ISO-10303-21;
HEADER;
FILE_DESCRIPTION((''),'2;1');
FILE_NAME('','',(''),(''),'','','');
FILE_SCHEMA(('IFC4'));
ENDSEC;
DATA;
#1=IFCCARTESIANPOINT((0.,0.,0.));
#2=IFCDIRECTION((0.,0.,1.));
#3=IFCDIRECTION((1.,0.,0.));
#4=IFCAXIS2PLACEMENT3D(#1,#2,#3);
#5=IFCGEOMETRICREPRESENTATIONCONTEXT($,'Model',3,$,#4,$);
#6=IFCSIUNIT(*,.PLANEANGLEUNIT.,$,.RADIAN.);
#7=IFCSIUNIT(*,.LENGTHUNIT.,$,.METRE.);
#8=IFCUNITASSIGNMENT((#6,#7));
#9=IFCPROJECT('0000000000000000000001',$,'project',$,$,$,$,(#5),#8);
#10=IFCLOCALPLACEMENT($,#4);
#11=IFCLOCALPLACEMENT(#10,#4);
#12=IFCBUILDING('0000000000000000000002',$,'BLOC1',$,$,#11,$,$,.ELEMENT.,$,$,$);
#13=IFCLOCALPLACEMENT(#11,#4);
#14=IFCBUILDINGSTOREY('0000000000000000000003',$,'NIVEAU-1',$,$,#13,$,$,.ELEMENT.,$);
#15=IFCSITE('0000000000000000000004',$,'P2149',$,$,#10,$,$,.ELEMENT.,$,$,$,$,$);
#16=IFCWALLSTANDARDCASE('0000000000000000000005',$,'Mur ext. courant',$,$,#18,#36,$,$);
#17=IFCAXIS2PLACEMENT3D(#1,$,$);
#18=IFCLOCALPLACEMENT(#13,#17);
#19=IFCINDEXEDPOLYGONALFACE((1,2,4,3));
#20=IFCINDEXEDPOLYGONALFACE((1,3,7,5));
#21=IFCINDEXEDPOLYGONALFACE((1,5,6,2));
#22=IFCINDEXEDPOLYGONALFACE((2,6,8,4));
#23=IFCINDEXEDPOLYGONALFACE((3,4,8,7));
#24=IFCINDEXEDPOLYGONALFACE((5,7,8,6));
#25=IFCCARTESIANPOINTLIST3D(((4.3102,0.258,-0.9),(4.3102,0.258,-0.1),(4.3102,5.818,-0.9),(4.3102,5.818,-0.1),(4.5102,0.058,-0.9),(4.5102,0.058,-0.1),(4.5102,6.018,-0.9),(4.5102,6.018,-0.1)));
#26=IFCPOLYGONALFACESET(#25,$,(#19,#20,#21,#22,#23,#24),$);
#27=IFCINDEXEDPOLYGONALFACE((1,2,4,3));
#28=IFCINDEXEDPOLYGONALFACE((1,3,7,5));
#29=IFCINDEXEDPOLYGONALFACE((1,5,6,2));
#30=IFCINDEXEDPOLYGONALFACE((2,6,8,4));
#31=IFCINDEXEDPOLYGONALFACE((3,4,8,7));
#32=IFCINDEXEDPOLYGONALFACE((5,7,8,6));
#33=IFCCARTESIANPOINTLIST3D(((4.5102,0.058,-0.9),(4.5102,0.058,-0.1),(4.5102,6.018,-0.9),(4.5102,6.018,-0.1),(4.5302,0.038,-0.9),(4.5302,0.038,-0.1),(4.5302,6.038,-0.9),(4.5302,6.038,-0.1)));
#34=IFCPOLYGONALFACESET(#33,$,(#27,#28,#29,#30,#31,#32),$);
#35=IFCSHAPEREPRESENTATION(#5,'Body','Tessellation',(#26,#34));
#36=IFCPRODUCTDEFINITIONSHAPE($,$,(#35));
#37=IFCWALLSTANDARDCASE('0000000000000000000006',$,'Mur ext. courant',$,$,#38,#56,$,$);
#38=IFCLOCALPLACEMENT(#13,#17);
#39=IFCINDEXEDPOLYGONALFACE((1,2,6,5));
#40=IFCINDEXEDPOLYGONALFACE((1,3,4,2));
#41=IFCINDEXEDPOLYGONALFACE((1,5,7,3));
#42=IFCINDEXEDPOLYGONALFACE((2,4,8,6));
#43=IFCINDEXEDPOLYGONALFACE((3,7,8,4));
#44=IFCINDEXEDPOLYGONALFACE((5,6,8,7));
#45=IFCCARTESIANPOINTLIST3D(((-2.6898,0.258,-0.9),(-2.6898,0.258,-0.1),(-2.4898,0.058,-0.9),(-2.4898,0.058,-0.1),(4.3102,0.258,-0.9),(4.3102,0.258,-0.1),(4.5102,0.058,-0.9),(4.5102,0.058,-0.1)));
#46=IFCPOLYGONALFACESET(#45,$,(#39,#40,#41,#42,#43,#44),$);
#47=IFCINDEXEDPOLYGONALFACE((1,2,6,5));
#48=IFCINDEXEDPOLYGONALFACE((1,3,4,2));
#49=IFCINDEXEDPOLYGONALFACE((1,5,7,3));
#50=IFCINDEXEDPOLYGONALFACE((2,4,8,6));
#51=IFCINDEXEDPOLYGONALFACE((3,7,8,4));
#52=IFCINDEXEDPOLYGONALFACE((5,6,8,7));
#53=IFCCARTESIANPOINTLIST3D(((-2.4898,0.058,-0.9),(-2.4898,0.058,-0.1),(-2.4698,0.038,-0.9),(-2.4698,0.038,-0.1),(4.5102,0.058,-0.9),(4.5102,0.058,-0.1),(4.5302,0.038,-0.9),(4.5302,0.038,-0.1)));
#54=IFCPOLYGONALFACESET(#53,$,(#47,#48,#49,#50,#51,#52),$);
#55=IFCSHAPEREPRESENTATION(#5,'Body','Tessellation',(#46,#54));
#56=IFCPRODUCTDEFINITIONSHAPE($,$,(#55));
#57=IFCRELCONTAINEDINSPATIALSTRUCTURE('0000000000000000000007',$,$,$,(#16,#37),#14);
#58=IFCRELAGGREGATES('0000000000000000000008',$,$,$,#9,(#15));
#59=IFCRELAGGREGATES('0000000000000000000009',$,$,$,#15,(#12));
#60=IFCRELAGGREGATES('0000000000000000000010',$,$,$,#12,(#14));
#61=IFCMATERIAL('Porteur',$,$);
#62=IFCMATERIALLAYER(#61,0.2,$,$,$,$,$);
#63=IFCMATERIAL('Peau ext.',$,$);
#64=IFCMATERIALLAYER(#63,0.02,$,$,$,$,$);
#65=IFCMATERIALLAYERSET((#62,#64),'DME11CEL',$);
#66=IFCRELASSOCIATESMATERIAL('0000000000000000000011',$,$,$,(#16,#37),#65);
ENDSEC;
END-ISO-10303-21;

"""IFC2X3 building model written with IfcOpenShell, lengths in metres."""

from ifc_helpers import new_model, si_unit, point, frame, origin_with_axes, place, context, project, spatial, line_curve, trimmed, segment, composite_curve, outline, extrude, material, layer, layer_set, layer_usage, element, save


model = new_model("IFC2X3")

# Units and contexts
model_context = context("Model", 3, world=origin_with_axes())
ifc_project = project(units=[si_unit("PLANEANGLEUNIT", "RADIAN"), si_unit("LENGTHUNIT", "METRE")], contexts=[model_context])

# Site, building, storey
site_placement = place(None, origin_with_axes())
site = spatial("IfcSite", under=ifc_project, at=site_placement, Name="P2149", CompositionType="ELEMENT")
building_placement = place(site_placement, origin_with_axes())
building = spatial("IfcBuilding", under=site, at=building_placement, Name="BLOC1", CompositionType="ELEMENT")
storey_placement = place(building_placement, origin_with_axes())
storey = spatial("IfcBuildingStorey", under=building, at=storey_placement, Name="NIVEAU-1", CompositionType="ELEMENT")

# Walls
ifc_material_1 = material(Name="Porteur")
ifc_layer_1 = layer(ifc_material_1, 0.2)
ifc_material_2 = material(Name="Peau ext.")
ifc_layer_2 = layer(ifc_material_2, 0.02)
ifc_layer_set_1 = layer_set([ifc_layer_1, ifc_layer_2], Name="DME11CEL")
ifc_layer_usage_1 = layer_usage(ifc_layer_set_1, "AXIS2", "POSITIVE", 0.0)
wall_1_placement = place(storey_placement, frame((4.3102, 5.818, -0.9), z_axis=(0.0, 0.0, 1.0), x_axis=(0.0, -1.0, 0.0)))
element("IfcWallStandardCase", 1, at=wall_1_placement, inside=storey, material=ifc_layer_usage_1, Name="Mur ext. courant", context=model_context, shape_type="SweptSolid", body=[
    extrude(outline(composite_curve([segment(trimmed(line_curve((0.0, 0.0), (1.0, 0.0), 5.56), [point((0.0, 0.0))], [point((5.56, 0.0))], True, "CARTESIAN"), True, "CONTINUOUS"), segment(trimmed(line_curve((5.56, 0.0), (0.707107, 0.707107), 0.282843), [point((5.56, 0.0))], [point((5.76, 0.2))], True, "CARTESIAN"), True, "CONTINUOUS"), segment(trimmed(line_curve((5.76, 0.2), (-1.0, 0.0), 5.96), [point((5.76, 0.2))], [point((-0.2, 0.2))], True, "CARTESIAN"), True, "CONTINUOUS"), segment(trimmed(line_curve((-0.2, 0.2), (0.707107, -0.707107), 0.282843), [point((-0.2, 0.2))], [point((0.0, 0.0))], True, "CARTESIAN"), True, "CONTINUOUS")], self_intersect=False)), origin_with_axes(), (0.0, 0.0, 1.0), 0.8),
    extrude(outline(composite_curve([segment(trimmed(line_curve((-0.2, 0.2), (1.0, 0.0), 5.96), [point((-0.2, 0.2))], [point((5.76, 0.2))], True, "CARTESIAN"), True, "CONTINUOUS"), segment(trimmed(line_curve((5.76, 0.2), (0.707107, 0.707107), 0.028284), [point((5.76, 0.2))], [point((5.78, 0.22))], True, "CARTESIAN"), True, "CONTINUOUS"), segment(trimmed(line_curve((5.78, 0.22), (-1.0, 0.0), 6.0), [point((5.78, 0.22))], [point((-0.22, 0.22))], True, "CARTESIAN"), True, "CONTINUOUS"), segment(trimmed(line_curve((-0.22, 0.22), (0.707107, -0.707107), 0.028284), [point((-0.22, 0.22))], [point((-0.2, 0.2))], True, "CARTESIAN"), True, "CONTINUOUS")], self_intersect=False)), origin_with_axes(), (0.0, 0.0, 1.0), 0.8),
])
wall_2_placement = place(storey_placement, frame((4.3102, 0.258, -0.9), z_axis=(0.0, 0.0, 1.0), x_axis=(-1.0, 0.0, 0.0)))
element("IfcWallStandardCase", 2, at=wall_2_placement, inside=storey, material=ifc_layer_usage_1, Name="Mur ext. courant", context=model_context, shape_type="SweptSolid", body=[
    extrude(outline(composite_curve([segment(trimmed(line_curve((0.0, 0.0), (1.0, 0.0), 7.0), [point((0.0, 0.0))], [point((7.0, 0.0))], True, "CARTESIAN"), True, "CONTINUOUS"), segment(trimmed(line_curve((7.0, 0.0), (-0.707107, 0.707107), 0.282843), [point((7.0, 0.0))], [point((6.8, 0.2))], True, "CARTESIAN"), True, "CONTINUOUS"), segment(trimmed(line_curve((6.8, 0.2), (-1.0, 0.0), 7.0), [point((6.8, 0.2))], [point((-0.2, 0.2))], True, "CARTESIAN"), True, "CONTINUOUS"), segment(trimmed(line_curve((-0.2, 0.2), (0.707107, -0.707107), 0.282843), [point((-0.2, 0.2))], [point((0.0, 0.0))], True, "CARTESIAN"), True, "CONTINUOUS")], self_intersect=False)), origin_with_axes(), (0.0, 0.0, 1.0), 0.8),
    extrude(outline(composite_curve([segment(trimmed(line_curve((-0.2, 0.2), (1.0, 0.0), 7.0), [point((-0.2, 0.2))], [point((6.8, 0.2))], True, "CARTESIAN"), True, "CONTINUOUS"), segment(trimmed(line_curve((6.8, 0.2), (-0.707107, 0.707107), 0.028284), [point((6.8, 0.2))], [point((6.78, 0.22))], True, "CARTESIAN"), True, "CONTINUOUS"), segment(trimmed(line_curve((6.78, 0.22), (-1.0, 0.0), 7.0), [point((6.78, 0.22))], [point((-0.22, 0.22))], True, "CARTESIAN"), True, "CONTINUOUS"), segment(trimmed(line_curve((-0.22, 0.22), (0.707107, -0.707107), 0.028284), [point((-0.22, 0.22))], [point((-0.2, 0.2))], True, "CARTESIAN"), True, "CONTINUOUS")], self_intersect=False)), origin_with_axes(), (0.0, 0.0, 1.0), 0.8),
])

save(model, "model.ifc")
